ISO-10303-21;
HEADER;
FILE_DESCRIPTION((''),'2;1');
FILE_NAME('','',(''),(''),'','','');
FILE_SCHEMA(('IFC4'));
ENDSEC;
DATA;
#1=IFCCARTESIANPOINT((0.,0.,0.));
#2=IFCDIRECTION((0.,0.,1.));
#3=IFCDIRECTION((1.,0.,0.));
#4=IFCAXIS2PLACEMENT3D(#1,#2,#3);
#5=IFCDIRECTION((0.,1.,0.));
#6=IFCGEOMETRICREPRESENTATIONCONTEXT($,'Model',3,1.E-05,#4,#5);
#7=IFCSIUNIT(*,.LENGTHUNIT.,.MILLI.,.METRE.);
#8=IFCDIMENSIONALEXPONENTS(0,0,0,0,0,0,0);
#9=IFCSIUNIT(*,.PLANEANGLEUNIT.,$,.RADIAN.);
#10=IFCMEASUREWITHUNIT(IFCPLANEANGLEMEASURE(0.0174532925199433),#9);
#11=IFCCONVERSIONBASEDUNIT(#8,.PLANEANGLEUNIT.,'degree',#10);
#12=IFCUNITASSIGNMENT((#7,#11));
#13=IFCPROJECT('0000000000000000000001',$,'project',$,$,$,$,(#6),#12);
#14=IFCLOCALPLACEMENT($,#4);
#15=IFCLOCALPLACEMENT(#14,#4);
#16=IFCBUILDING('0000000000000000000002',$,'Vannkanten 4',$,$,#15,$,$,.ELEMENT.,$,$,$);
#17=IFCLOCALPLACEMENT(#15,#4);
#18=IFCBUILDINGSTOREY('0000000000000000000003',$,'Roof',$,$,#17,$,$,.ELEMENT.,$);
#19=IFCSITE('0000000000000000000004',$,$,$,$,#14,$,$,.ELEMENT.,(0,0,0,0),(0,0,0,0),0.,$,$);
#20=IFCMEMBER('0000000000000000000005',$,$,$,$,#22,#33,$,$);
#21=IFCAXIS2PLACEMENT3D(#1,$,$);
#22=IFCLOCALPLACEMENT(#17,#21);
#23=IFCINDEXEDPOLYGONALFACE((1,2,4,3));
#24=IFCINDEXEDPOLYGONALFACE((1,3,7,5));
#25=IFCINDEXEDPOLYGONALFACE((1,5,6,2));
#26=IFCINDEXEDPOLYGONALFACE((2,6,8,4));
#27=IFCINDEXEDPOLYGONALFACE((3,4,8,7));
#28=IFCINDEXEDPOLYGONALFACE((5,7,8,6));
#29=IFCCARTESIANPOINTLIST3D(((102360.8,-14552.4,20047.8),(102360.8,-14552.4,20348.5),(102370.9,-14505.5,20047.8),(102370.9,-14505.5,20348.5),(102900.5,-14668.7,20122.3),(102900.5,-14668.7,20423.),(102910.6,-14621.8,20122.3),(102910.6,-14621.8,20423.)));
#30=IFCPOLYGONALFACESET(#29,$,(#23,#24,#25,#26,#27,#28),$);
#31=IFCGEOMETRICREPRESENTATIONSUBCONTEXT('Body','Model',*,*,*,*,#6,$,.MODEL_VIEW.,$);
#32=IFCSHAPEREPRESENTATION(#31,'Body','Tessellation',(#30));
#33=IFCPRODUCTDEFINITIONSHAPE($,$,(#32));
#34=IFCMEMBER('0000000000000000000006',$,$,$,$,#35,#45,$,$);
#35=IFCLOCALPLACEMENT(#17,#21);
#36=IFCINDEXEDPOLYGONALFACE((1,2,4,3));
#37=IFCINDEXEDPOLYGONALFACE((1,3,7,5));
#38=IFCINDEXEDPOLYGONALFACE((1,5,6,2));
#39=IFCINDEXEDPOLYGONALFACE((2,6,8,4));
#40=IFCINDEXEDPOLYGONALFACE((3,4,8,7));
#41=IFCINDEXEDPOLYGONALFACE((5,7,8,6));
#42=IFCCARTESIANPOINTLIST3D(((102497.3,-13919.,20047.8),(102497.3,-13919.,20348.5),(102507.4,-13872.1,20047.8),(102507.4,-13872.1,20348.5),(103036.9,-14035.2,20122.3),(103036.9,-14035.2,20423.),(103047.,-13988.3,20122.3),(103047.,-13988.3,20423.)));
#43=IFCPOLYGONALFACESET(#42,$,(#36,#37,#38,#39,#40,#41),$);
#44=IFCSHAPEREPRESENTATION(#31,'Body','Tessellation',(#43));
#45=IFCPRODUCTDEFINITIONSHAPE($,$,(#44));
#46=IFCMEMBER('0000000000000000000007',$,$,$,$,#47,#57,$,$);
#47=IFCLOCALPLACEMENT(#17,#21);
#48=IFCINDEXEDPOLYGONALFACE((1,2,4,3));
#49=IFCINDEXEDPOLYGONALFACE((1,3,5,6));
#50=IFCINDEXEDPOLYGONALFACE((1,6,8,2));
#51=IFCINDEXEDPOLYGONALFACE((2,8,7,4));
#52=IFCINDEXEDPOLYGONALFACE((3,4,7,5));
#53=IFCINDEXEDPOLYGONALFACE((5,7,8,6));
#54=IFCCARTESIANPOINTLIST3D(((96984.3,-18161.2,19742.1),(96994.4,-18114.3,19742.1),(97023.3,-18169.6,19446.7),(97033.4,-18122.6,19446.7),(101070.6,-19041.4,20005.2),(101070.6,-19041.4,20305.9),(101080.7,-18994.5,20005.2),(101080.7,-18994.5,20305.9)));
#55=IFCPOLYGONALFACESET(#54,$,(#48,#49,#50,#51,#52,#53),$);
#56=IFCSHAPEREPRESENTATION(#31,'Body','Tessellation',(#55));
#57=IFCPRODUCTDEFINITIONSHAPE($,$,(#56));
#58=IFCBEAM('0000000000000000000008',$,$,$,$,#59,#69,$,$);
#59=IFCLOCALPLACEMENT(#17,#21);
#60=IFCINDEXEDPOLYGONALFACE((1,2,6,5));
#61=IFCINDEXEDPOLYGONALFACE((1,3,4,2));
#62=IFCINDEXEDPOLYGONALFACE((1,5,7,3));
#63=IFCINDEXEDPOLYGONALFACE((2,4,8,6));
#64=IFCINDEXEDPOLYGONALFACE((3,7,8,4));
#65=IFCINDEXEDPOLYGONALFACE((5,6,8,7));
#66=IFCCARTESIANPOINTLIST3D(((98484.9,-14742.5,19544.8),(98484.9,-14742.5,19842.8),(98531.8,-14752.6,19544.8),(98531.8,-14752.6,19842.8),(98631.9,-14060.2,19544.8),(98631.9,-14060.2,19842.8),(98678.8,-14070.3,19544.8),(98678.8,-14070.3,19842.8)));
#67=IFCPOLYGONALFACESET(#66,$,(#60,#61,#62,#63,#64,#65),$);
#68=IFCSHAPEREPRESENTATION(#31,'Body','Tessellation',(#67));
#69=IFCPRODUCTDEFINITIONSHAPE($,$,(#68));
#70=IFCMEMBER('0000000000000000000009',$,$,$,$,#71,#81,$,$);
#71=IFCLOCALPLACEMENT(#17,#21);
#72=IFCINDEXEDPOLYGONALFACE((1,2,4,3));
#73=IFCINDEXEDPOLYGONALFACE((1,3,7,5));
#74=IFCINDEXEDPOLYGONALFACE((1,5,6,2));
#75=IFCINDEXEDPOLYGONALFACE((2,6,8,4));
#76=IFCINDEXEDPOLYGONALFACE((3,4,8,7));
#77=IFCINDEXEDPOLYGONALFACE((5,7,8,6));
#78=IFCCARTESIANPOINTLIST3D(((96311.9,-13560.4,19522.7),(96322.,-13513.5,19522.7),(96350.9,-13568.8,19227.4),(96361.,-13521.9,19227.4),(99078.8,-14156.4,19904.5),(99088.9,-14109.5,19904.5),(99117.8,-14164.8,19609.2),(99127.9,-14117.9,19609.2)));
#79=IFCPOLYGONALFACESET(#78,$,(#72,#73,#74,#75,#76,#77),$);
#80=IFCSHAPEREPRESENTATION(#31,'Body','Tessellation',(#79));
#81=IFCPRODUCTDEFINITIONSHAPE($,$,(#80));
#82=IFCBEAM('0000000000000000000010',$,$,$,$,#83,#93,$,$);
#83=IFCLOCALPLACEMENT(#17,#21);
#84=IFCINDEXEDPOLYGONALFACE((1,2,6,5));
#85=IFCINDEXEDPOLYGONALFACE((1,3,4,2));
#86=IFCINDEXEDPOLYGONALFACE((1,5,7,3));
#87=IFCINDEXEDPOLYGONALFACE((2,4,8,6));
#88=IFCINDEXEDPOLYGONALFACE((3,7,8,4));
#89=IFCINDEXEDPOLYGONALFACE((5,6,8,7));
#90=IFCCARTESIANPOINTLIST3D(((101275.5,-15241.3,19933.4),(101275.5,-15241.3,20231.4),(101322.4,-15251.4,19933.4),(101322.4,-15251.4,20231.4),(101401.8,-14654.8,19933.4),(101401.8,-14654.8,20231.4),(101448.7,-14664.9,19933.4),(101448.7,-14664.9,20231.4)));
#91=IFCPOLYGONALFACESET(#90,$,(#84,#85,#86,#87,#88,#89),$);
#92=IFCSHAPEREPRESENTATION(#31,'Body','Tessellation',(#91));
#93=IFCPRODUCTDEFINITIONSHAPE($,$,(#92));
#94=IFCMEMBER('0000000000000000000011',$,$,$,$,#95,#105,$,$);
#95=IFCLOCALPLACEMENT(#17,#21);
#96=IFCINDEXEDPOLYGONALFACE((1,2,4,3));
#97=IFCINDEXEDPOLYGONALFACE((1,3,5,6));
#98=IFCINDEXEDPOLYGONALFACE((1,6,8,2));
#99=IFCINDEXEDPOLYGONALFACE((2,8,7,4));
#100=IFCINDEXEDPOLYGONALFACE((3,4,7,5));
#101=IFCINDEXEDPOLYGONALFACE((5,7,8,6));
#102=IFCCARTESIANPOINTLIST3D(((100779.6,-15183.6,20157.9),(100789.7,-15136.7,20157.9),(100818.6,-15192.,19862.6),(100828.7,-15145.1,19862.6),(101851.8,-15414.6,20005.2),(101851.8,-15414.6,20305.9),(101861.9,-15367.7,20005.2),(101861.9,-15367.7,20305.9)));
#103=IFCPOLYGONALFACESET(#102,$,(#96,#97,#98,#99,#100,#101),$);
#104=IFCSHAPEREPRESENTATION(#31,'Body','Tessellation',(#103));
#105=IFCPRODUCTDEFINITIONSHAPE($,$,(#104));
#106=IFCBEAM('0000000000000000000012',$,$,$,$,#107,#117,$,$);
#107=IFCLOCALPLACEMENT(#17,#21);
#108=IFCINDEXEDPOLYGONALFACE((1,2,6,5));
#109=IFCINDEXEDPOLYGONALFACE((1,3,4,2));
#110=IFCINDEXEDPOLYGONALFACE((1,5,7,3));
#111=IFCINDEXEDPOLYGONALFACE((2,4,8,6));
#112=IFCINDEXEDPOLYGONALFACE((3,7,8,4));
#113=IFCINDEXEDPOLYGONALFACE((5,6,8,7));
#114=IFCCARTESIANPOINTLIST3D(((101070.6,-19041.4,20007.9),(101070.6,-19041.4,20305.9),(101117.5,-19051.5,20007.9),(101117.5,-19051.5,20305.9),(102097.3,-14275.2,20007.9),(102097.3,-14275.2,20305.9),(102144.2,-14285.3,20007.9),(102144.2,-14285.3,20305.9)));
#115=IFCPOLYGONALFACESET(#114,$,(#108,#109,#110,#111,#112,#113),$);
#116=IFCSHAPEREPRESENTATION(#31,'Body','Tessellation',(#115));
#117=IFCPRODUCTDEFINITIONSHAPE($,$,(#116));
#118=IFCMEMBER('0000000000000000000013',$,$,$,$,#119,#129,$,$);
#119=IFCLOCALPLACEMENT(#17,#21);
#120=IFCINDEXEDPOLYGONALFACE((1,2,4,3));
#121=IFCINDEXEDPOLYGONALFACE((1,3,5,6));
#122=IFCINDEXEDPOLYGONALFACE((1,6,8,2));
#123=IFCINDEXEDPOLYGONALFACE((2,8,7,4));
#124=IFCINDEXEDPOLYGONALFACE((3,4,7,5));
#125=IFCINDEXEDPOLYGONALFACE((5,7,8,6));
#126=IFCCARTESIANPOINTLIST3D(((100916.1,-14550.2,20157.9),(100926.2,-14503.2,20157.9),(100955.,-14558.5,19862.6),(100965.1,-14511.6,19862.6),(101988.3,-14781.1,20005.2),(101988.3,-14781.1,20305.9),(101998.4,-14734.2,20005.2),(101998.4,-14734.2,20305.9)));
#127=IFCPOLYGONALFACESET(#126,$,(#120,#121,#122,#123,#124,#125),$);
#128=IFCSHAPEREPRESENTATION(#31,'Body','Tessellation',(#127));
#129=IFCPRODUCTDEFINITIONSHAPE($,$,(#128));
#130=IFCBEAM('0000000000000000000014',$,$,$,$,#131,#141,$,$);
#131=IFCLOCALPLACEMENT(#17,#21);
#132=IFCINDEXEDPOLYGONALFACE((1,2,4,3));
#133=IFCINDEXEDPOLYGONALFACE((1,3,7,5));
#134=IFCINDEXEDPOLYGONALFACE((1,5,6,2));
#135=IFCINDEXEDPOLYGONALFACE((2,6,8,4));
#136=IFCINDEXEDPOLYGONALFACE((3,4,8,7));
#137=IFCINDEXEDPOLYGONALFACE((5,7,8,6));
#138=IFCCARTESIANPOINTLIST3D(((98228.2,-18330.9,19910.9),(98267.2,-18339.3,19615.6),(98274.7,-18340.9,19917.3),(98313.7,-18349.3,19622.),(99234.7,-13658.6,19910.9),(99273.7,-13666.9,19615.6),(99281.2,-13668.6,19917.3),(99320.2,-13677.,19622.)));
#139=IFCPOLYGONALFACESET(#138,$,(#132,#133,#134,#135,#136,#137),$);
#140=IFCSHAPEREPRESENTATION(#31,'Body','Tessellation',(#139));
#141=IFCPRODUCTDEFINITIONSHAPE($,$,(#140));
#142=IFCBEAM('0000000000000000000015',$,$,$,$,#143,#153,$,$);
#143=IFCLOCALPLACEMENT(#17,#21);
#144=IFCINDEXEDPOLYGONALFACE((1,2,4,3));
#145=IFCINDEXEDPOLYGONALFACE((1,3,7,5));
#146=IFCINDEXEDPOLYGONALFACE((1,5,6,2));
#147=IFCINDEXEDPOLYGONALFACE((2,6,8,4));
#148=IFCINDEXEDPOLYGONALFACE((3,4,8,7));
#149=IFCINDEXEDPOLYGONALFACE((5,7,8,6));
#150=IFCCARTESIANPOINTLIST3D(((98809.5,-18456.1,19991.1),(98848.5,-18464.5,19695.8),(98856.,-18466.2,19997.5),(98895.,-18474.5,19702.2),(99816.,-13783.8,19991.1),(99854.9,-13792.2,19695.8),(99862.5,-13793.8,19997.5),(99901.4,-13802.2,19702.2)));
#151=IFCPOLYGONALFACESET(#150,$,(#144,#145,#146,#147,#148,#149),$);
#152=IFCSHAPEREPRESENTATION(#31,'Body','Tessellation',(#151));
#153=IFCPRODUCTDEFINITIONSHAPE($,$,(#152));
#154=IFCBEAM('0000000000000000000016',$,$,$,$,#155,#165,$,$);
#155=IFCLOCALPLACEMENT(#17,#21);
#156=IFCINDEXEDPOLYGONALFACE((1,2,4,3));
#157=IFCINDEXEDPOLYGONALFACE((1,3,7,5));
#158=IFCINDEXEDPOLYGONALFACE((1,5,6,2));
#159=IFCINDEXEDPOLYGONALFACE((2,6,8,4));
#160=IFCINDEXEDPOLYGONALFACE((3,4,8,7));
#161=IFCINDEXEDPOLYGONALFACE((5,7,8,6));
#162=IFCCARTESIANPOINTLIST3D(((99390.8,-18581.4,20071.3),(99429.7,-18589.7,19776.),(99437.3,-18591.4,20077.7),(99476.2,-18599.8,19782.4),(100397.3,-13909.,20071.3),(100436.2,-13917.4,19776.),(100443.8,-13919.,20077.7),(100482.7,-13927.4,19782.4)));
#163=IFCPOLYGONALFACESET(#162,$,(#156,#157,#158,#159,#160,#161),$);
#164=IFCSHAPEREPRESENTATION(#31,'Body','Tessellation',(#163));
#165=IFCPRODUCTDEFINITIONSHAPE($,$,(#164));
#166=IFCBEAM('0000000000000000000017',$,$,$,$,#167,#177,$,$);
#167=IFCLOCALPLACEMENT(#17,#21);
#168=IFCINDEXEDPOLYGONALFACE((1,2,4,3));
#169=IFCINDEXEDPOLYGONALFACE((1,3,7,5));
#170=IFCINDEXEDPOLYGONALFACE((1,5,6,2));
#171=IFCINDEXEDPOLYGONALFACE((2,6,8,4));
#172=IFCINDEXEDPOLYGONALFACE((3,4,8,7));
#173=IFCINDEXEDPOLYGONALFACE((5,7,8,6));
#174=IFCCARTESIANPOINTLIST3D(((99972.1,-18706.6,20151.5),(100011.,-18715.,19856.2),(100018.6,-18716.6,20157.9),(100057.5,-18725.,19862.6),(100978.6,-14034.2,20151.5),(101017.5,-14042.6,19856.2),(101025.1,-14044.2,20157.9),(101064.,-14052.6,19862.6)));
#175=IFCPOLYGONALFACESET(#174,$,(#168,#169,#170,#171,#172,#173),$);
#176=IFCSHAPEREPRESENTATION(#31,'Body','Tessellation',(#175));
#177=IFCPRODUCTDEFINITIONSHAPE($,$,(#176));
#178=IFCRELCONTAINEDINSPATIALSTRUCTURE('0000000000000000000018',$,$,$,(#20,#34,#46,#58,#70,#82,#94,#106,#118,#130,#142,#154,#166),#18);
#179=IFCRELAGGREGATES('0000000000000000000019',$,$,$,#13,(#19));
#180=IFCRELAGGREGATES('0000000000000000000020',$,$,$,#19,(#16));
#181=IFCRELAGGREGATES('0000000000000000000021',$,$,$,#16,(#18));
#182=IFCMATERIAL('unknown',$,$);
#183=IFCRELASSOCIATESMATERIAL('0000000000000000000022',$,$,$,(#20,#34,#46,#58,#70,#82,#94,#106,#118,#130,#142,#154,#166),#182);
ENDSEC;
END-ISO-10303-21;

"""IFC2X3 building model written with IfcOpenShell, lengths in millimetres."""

from ifc_helpers import new_model, entity, si_unit, converted_unit, direction, frame, origin_with_axes, place, context, subcontext, project, spatial, polyline, segment, composite_curve, outline, extrude, clip, halfspace, material, element, save


model = new_model("IFC2X3")

# Units and contexts
model_context = context("Model", 3, precision=1e-05, world=origin_with_axes(), true_north=direction((0.0, 1.0, 0.0)))
body_context = subcontext(model_context, "Body", "Model", "MODEL_VIEW")
ifc_project = project(units=[si_unit("LENGTHUNIT", "METRE", prefix="MILLI"), converted_unit("PLANEANGLEUNIT", "degree", entity("IfcPlaneAngleMeasure", 0.0174532925199433), si_unit("PLANEANGLEUNIT", "RADIAN"), dimensions=[0, 0, 0, 0, 0, 0, 0])], contexts=[model_context])

# Site, building, storey
site_placement = place(None, origin_with_axes())
site = spatial("IfcSite", under=ifc_project, at=site_placement, CompositionType="ELEMENT", RefLatitude=(0, 0, 0, 0), RefLongitude=(0, 0, 0, 0), RefElevation=0.0)
building_placement = place(site_placement, origin_with_axes())
building = spatial("IfcBuilding", under=site, at=building_placement, Name="Vannkanten 4", CompositionType="ELEMENT")
storey_placement = place(building_placement, origin_with_axes())
storey = spatial("IfcBuildingStorey", under=building, at=storey_placement, Name="Roof", CompositionType="ELEMENT")

# Shared definitions
ifc_material = material(Name="unknown")

# Members
member_1_placement = place(storey_placement, frame((102365.8, -14529.0, 20198.2), z_axis=(0.968803, -0.208692, 0.133675), x_axis=(0.210582, 0.977576, 0.0)))
element("IfcMember", 1, at=member_1_placement, inside=storey, material=ifc_material, context=body_context, shape_type="Clipping", body=[
    clip(clip(extrude(outline(composite_curve([segment(polyline([(-24.0, -149.0), (-24.0, 149.0), (24.0, 149.0), (24.0, -149.0), (-24.0, -149.0)]), True, "CONTINUOUS")], self_intersect=False)), frame((0.0, 0.0, -318.7), z_axis=(0.0, 0.0, 1.0), x_axis=(1.0, 0.0, 0.0)), (0.0, 0.0, 1.0), 1194.6), halfspace(frame((-24.0, 149.0, 20.1), z_axis=(-0.000083, -0.133675, 0.991025), x_axis=(0.0, 0.991025, 0.133675)), True)), halfspace(frame((24.0, 149.0, 577.2), z_axis=(0.0, 0.133675, -0.991025), x_axis=(0.0, -0.991025, -0.133675)), True)),
])
member_2_placement = place(storey_placement, frame((103042.0, -14011.8, 20272.6), z_axis=(-0.968803, 0.208692, -0.133675), x_axis=(-0.210582, -0.977576, 0.0)))
element("IfcMember", 2, at=member_2_placement, inside=storey, material=ifc_material, context=body_context, shape_type="Clipping", body=[
    clip(clip(extrude(outline(composite_curve([segment(polyline([(-24.0, -149.0), (-24.0, 149.0), (24.0, 149.0), (24.0, -149.0), (-24.0, -149.0)]), True, "CONTINUOUS")], self_intersect=False)), frame((0.0, 0.0, -318.7), z_axis=(0.0, 0.0, 1.0), x_axis=(1.0, 0.0, 0.0)), (0.0, 0.0, 1.0), 1194.5), halfspace(frame((-24.0, 149.0, -20.1), z_axis=(0.0, 0.133675, 0.991025), x_axis=(0.0, 0.991025, -0.133675)), True)), halfspace(frame((24.0, 149.0, 537.0), z_axis=(0.000083, -0.133675, -0.991025), x_axis=(0.0, -0.991025, 0.133675)), True)),
])
member_3_placement = place(storey_placement, frame((101075.6, -19017.9, 20155.5), z_axis=(-0.968803, 0.208692, -0.133675), x_axis=(-0.210582, -0.977576, 0.0)))
element("IfcMember", 3, at=member_3_placement, inside=storey, material=ifc_material, context=body_context, shape_type="Clipping", body=[
    clip(extrude(outline(composite_curve([segment(polyline([(-24.0, -149.0), (-24.0, 149.0), (24.0, 149.0), (24.0, -149.0), (-24.0, -149.0)]), True, "CONTINUOUS")], self_intersect=False)), frame((0.0, 0.0, -2129.0), z_axis=(0.0, 0.0, 1.0), x_axis=(1.0, 0.0, 0.0)), (0.0, 0.0, 1.0), 6326.7), halfspace(frame((-24.0, 149.0, -20.1), z_axis=(0.0, 0.133675, 0.991025), x_axis=(0.0, 0.991025, -0.133675)), True)),
])

# Beam
beam_1_placement = place(storey_placement, frame((98508.4, -14747.6, 19693.8), z_axis=(0.210582, 0.977576, 0.0), x_axis=(-0.977576, 0.210582, 0.0)))
element("IfcBeam", 4, at=beam_1_placement, inside=storey, material=ifc_material, context=body_context, shape_type="SweptSolid", body=[
    extrude(outline(composite_curve([segment(polyline([(-24.0, -149.0), (-24.0, 149.0), (24.0, 149.0), (24.0, -149.0), (-24.0, -149.0)]), True, "CONTINUOUS")], self_intersect=False)), frame((0.0, 0.0, 0.0), z_axis=(0.0, 0.0, 1.0), x_axis=(1.0, 0.0, 0.0)), (0.0, 0.0, 1.0), 698.0),
])

# Member
member_4_placement = place(storey_placement, frame((99103.3, -14137.2, 19756.8), z_axis=(-0.968803, 0.208692, -0.133675), x_axis=(-0.210582, -0.977576, 0.0)))
element("IfcMember", 5, at=member_4_placement, inside=storey, material=ifc_material, context=body_context, shape_type="SweptSolid", body=[
    extrude(outline(composite_curve([segment(polyline([(-24.0, -149.0), (-24.0, 149.0), (24.0, 149.0), (24.0, -149.0), (-24.0, -149.0)]), True, "CONTINUOUS")], self_intersect=False)), frame((0.0, 0.0, 0.0), z_axis=(0.0, 0.0, 1.0), x_axis=(1.0, 0.0, 0.0)), (0.0, 0.0, 1.0), 2856.0),
])

# Beam
beam_2_placement = place(storey_placement, frame((101425.3, -14659.8, 20082.4), z_axis=(-0.210582, -0.977576, 0.0), x_axis=(0.977576, -0.210582, 0.0)))
element("IfcBeam", 6, at=beam_2_placement, inside=storey, material=ifc_material, context=body_context, shape_type="SweptSolid", body=[
    extrude(outline(composite_curve([segment(polyline([(-24.0, -149.0), (-24.0, 149.0), (24.0, 149.0), (24.0, -149.0), (-24.0, -149.0)]), True, "CONTINUOUS")], self_intersect=False)), frame((0.0, 0.0, 0.0), z_axis=(0.0, 0.0, 1.0), x_axis=(1.0, 0.0, 0.0)), (0.0, 0.0, 1.0), 600.0),
])

# Member
member_5_placement = place(storey_placement, frame((100804.1, -15164.4, 20010.3), z_axis=(0.968803, -0.208692, 0.133675), x_axis=(0.210582, 0.977576, 0.0)))
element("IfcMember", 7, at=member_5_placement, inside=storey, material=ifc_material, context=body_context, shape_type="Clipping", body=[
    clip(extrude(outline(composite_curve([segment(polyline([(-24.0, -149.0), (-24.0, 149.0), (24.0, 149.0), (24.0, -149.0), (-24.0, -149.0)]), True, "CONTINUOUS")], self_intersect=False)), frame((0.0, 0.0, 0.0), z_axis=(0.0, 0.0, 1.0), x_axis=(1.0, 0.0, 0.0)), (0.0, 0.0, 1.0), 1660.1), halfspace(frame((-24.0, -149.0, 1066.5), z_axis=(0.0, 0.133675, -0.991025), x_axis=(0.0, -0.991025, -0.133675)), True)),
])

# Beam
beam_3_placement = place(storey_placement, frame((101094.0, -19046.5, 20156.9), z_axis=(0.210582, 0.977576, 0.0), x_axis=(-0.977576, 0.210582, 0.0)))
element("IfcBeam", 8, at=beam_3_placement, inside=storey, material=ifc_material, context=body_context, shape_type="SweptSolid", body=[
    extrude(outline(composite_curve([segment(polyline([(-24.0, -149.0), (-24.0, 149.0), (24.0, 149.0), (24.0, -149.0), (-24.0, -149.0)]), True, "CONTINUOUS")], self_intersect=False)), frame((0.0, 0.0, 0.0), z_axis=(0.0, 0.0, 1.0), x_axis=(1.0, 0.0, 0.0)), (0.0, 0.0, 1.0), 4875.6),
])

# Member
member_6_placement = place(storey_placement, frame((101993.4, -14757.7, 20155.5), z_axis=(-0.968803, 0.208692, -0.133675), x_axis=(-0.210582, -0.977576, 0.0)))
element("IfcMember", 9, at=member_6_placement, inside=storey, material=ifc_material, context=body_context, shape_type="Clipping", body=[
    clip(extrude(outline(composite_curve([segment(polyline([(-24.0, -149.0), (-24.0, 149.0), (24.0, 149.0), (24.0, -149.0), (-24.0, -149.0)]), True, "CONTINUOUS")], self_intersect=False)), frame((0.0, 0.0, -573.5), z_axis=(0.0, 0.0, 1.0), x_axis=(1.0, 0.0, 0.0)), (0.0, 0.0, 1.0), 1660.1), halfspace(frame((-24.0, 149.0, -20.1), z_axis=(0.0, 0.133675, 0.991025), x_axis=(0.0, 0.991025, -0.133675)), True)),
])

# Beams
beam_4_placement = place(storey_placement, frame((98271.0, -18340.1, 19766.5), z_axis=(0.210582, 0.977576, 0.0), x_axis=(-0.968803, 0.208692, -0.133675)))
element("IfcBeam", 10, at=beam_4_placement, inside=storey, material=ifc_material, context=body_context, shape_type="SweptSolid", body=[
    extrude(outline(composite_curve([segment(polyline([(-24.0, -149.0), (-24.0, 149.0), (24.0, 149.0), (24.0, -149.0), (-24.0, -149.0)]), True, "CONTINUOUS")], self_intersect=False)), frame((0.0, 0.0, 0.0), z_axis=(0.0, 0.0, 1.0), x_axis=(1.0, 0.0, 0.0)), (0.0, 0.0, 1.0), 4779.6),
])
beam_5_placement = place(storey_placement, frame((98852.2, -18465.3, 19846.7), z_axis=(0.210582, 0.977576, 0.0), x_axis=(-0.968803, 0.208692, -0.133675)))
element("IfcBeam", 11, at=beam_5_placement, inside=storey, material=ifc_material, context=body_context, shape_type="SweptSolid", body=[
    extrude(outline(composite_curve([segment(polyline([(-24.0, -149.0), (-24.0, 149.0), (24.0, 149.0), (24.0, -149.0), (-24.0, -149.0)]), True, "CONTINUOUS")], self_intersect=False)), frame((0.0, 0.0, 0.0), z_axis=(0.0, 0.0, 1.0), x_axis=(1.0, 0.0, 0.0)), (0.0, 0.0, 1.0), 4779.6),
])
beam_6_placement = place(storey_placement, frame((99433.5, -18590.6, 19926.9), z_axis=(0.210582, 0.977576, 0.0), x_axis=(-0.968803, 0.208692, -0.133675)))
element("IfcBeam", 12, at=beam_6_placement, inside=storey, material=ifc_material, context=body_context, shape_type="SweptSolid", body=[
    extrude(outline(composite_curve([segment(polyline([(-24.0, -149.0), (-24.0, 149.0), (24.0, 149.0), (24.0, -149.0), (-24.0, -149.0)]), True, "CONTINUOUS")], self_intersect=False)), frame((0.0, 0.0, 0.0), z_axis=(0.0, 0.0, 1.0), x_axis=(1.0, 0.0, 0.0)), (0.0, 0.0, 1.0), 4779.6),
])
beam_7_placement = place(storey_placement, frame((100014.8, -18715.8, 20007.1), z_axis=(0.210582, 0.977576, 0.0), x_axis=(-0.968803, 0.208692, -0.133675)))
element("IfcBeam", 13, at=beam_7_placement, inside=storey, material=ifc_material, context=body_context, shape_type="SweptSolid", body=[
    extrude(outline(composite_curve([segment(polyline([(-24.0, -149.0), (-24.0, 149.0), (24.0, 149.0), (24.0, -149.0), (-24.0, -149.0)]), True, "CONTINUOUS")], self_intersect=False)), frame((0.0, 0.0, 0.0), z_axis=(0.0, 0.0, 1.0), x_axis=(1.0, 0.0, 0.0)), (0.0, 0.0, 1.0), 4779.6),
])

save(model, "model.ifc")
